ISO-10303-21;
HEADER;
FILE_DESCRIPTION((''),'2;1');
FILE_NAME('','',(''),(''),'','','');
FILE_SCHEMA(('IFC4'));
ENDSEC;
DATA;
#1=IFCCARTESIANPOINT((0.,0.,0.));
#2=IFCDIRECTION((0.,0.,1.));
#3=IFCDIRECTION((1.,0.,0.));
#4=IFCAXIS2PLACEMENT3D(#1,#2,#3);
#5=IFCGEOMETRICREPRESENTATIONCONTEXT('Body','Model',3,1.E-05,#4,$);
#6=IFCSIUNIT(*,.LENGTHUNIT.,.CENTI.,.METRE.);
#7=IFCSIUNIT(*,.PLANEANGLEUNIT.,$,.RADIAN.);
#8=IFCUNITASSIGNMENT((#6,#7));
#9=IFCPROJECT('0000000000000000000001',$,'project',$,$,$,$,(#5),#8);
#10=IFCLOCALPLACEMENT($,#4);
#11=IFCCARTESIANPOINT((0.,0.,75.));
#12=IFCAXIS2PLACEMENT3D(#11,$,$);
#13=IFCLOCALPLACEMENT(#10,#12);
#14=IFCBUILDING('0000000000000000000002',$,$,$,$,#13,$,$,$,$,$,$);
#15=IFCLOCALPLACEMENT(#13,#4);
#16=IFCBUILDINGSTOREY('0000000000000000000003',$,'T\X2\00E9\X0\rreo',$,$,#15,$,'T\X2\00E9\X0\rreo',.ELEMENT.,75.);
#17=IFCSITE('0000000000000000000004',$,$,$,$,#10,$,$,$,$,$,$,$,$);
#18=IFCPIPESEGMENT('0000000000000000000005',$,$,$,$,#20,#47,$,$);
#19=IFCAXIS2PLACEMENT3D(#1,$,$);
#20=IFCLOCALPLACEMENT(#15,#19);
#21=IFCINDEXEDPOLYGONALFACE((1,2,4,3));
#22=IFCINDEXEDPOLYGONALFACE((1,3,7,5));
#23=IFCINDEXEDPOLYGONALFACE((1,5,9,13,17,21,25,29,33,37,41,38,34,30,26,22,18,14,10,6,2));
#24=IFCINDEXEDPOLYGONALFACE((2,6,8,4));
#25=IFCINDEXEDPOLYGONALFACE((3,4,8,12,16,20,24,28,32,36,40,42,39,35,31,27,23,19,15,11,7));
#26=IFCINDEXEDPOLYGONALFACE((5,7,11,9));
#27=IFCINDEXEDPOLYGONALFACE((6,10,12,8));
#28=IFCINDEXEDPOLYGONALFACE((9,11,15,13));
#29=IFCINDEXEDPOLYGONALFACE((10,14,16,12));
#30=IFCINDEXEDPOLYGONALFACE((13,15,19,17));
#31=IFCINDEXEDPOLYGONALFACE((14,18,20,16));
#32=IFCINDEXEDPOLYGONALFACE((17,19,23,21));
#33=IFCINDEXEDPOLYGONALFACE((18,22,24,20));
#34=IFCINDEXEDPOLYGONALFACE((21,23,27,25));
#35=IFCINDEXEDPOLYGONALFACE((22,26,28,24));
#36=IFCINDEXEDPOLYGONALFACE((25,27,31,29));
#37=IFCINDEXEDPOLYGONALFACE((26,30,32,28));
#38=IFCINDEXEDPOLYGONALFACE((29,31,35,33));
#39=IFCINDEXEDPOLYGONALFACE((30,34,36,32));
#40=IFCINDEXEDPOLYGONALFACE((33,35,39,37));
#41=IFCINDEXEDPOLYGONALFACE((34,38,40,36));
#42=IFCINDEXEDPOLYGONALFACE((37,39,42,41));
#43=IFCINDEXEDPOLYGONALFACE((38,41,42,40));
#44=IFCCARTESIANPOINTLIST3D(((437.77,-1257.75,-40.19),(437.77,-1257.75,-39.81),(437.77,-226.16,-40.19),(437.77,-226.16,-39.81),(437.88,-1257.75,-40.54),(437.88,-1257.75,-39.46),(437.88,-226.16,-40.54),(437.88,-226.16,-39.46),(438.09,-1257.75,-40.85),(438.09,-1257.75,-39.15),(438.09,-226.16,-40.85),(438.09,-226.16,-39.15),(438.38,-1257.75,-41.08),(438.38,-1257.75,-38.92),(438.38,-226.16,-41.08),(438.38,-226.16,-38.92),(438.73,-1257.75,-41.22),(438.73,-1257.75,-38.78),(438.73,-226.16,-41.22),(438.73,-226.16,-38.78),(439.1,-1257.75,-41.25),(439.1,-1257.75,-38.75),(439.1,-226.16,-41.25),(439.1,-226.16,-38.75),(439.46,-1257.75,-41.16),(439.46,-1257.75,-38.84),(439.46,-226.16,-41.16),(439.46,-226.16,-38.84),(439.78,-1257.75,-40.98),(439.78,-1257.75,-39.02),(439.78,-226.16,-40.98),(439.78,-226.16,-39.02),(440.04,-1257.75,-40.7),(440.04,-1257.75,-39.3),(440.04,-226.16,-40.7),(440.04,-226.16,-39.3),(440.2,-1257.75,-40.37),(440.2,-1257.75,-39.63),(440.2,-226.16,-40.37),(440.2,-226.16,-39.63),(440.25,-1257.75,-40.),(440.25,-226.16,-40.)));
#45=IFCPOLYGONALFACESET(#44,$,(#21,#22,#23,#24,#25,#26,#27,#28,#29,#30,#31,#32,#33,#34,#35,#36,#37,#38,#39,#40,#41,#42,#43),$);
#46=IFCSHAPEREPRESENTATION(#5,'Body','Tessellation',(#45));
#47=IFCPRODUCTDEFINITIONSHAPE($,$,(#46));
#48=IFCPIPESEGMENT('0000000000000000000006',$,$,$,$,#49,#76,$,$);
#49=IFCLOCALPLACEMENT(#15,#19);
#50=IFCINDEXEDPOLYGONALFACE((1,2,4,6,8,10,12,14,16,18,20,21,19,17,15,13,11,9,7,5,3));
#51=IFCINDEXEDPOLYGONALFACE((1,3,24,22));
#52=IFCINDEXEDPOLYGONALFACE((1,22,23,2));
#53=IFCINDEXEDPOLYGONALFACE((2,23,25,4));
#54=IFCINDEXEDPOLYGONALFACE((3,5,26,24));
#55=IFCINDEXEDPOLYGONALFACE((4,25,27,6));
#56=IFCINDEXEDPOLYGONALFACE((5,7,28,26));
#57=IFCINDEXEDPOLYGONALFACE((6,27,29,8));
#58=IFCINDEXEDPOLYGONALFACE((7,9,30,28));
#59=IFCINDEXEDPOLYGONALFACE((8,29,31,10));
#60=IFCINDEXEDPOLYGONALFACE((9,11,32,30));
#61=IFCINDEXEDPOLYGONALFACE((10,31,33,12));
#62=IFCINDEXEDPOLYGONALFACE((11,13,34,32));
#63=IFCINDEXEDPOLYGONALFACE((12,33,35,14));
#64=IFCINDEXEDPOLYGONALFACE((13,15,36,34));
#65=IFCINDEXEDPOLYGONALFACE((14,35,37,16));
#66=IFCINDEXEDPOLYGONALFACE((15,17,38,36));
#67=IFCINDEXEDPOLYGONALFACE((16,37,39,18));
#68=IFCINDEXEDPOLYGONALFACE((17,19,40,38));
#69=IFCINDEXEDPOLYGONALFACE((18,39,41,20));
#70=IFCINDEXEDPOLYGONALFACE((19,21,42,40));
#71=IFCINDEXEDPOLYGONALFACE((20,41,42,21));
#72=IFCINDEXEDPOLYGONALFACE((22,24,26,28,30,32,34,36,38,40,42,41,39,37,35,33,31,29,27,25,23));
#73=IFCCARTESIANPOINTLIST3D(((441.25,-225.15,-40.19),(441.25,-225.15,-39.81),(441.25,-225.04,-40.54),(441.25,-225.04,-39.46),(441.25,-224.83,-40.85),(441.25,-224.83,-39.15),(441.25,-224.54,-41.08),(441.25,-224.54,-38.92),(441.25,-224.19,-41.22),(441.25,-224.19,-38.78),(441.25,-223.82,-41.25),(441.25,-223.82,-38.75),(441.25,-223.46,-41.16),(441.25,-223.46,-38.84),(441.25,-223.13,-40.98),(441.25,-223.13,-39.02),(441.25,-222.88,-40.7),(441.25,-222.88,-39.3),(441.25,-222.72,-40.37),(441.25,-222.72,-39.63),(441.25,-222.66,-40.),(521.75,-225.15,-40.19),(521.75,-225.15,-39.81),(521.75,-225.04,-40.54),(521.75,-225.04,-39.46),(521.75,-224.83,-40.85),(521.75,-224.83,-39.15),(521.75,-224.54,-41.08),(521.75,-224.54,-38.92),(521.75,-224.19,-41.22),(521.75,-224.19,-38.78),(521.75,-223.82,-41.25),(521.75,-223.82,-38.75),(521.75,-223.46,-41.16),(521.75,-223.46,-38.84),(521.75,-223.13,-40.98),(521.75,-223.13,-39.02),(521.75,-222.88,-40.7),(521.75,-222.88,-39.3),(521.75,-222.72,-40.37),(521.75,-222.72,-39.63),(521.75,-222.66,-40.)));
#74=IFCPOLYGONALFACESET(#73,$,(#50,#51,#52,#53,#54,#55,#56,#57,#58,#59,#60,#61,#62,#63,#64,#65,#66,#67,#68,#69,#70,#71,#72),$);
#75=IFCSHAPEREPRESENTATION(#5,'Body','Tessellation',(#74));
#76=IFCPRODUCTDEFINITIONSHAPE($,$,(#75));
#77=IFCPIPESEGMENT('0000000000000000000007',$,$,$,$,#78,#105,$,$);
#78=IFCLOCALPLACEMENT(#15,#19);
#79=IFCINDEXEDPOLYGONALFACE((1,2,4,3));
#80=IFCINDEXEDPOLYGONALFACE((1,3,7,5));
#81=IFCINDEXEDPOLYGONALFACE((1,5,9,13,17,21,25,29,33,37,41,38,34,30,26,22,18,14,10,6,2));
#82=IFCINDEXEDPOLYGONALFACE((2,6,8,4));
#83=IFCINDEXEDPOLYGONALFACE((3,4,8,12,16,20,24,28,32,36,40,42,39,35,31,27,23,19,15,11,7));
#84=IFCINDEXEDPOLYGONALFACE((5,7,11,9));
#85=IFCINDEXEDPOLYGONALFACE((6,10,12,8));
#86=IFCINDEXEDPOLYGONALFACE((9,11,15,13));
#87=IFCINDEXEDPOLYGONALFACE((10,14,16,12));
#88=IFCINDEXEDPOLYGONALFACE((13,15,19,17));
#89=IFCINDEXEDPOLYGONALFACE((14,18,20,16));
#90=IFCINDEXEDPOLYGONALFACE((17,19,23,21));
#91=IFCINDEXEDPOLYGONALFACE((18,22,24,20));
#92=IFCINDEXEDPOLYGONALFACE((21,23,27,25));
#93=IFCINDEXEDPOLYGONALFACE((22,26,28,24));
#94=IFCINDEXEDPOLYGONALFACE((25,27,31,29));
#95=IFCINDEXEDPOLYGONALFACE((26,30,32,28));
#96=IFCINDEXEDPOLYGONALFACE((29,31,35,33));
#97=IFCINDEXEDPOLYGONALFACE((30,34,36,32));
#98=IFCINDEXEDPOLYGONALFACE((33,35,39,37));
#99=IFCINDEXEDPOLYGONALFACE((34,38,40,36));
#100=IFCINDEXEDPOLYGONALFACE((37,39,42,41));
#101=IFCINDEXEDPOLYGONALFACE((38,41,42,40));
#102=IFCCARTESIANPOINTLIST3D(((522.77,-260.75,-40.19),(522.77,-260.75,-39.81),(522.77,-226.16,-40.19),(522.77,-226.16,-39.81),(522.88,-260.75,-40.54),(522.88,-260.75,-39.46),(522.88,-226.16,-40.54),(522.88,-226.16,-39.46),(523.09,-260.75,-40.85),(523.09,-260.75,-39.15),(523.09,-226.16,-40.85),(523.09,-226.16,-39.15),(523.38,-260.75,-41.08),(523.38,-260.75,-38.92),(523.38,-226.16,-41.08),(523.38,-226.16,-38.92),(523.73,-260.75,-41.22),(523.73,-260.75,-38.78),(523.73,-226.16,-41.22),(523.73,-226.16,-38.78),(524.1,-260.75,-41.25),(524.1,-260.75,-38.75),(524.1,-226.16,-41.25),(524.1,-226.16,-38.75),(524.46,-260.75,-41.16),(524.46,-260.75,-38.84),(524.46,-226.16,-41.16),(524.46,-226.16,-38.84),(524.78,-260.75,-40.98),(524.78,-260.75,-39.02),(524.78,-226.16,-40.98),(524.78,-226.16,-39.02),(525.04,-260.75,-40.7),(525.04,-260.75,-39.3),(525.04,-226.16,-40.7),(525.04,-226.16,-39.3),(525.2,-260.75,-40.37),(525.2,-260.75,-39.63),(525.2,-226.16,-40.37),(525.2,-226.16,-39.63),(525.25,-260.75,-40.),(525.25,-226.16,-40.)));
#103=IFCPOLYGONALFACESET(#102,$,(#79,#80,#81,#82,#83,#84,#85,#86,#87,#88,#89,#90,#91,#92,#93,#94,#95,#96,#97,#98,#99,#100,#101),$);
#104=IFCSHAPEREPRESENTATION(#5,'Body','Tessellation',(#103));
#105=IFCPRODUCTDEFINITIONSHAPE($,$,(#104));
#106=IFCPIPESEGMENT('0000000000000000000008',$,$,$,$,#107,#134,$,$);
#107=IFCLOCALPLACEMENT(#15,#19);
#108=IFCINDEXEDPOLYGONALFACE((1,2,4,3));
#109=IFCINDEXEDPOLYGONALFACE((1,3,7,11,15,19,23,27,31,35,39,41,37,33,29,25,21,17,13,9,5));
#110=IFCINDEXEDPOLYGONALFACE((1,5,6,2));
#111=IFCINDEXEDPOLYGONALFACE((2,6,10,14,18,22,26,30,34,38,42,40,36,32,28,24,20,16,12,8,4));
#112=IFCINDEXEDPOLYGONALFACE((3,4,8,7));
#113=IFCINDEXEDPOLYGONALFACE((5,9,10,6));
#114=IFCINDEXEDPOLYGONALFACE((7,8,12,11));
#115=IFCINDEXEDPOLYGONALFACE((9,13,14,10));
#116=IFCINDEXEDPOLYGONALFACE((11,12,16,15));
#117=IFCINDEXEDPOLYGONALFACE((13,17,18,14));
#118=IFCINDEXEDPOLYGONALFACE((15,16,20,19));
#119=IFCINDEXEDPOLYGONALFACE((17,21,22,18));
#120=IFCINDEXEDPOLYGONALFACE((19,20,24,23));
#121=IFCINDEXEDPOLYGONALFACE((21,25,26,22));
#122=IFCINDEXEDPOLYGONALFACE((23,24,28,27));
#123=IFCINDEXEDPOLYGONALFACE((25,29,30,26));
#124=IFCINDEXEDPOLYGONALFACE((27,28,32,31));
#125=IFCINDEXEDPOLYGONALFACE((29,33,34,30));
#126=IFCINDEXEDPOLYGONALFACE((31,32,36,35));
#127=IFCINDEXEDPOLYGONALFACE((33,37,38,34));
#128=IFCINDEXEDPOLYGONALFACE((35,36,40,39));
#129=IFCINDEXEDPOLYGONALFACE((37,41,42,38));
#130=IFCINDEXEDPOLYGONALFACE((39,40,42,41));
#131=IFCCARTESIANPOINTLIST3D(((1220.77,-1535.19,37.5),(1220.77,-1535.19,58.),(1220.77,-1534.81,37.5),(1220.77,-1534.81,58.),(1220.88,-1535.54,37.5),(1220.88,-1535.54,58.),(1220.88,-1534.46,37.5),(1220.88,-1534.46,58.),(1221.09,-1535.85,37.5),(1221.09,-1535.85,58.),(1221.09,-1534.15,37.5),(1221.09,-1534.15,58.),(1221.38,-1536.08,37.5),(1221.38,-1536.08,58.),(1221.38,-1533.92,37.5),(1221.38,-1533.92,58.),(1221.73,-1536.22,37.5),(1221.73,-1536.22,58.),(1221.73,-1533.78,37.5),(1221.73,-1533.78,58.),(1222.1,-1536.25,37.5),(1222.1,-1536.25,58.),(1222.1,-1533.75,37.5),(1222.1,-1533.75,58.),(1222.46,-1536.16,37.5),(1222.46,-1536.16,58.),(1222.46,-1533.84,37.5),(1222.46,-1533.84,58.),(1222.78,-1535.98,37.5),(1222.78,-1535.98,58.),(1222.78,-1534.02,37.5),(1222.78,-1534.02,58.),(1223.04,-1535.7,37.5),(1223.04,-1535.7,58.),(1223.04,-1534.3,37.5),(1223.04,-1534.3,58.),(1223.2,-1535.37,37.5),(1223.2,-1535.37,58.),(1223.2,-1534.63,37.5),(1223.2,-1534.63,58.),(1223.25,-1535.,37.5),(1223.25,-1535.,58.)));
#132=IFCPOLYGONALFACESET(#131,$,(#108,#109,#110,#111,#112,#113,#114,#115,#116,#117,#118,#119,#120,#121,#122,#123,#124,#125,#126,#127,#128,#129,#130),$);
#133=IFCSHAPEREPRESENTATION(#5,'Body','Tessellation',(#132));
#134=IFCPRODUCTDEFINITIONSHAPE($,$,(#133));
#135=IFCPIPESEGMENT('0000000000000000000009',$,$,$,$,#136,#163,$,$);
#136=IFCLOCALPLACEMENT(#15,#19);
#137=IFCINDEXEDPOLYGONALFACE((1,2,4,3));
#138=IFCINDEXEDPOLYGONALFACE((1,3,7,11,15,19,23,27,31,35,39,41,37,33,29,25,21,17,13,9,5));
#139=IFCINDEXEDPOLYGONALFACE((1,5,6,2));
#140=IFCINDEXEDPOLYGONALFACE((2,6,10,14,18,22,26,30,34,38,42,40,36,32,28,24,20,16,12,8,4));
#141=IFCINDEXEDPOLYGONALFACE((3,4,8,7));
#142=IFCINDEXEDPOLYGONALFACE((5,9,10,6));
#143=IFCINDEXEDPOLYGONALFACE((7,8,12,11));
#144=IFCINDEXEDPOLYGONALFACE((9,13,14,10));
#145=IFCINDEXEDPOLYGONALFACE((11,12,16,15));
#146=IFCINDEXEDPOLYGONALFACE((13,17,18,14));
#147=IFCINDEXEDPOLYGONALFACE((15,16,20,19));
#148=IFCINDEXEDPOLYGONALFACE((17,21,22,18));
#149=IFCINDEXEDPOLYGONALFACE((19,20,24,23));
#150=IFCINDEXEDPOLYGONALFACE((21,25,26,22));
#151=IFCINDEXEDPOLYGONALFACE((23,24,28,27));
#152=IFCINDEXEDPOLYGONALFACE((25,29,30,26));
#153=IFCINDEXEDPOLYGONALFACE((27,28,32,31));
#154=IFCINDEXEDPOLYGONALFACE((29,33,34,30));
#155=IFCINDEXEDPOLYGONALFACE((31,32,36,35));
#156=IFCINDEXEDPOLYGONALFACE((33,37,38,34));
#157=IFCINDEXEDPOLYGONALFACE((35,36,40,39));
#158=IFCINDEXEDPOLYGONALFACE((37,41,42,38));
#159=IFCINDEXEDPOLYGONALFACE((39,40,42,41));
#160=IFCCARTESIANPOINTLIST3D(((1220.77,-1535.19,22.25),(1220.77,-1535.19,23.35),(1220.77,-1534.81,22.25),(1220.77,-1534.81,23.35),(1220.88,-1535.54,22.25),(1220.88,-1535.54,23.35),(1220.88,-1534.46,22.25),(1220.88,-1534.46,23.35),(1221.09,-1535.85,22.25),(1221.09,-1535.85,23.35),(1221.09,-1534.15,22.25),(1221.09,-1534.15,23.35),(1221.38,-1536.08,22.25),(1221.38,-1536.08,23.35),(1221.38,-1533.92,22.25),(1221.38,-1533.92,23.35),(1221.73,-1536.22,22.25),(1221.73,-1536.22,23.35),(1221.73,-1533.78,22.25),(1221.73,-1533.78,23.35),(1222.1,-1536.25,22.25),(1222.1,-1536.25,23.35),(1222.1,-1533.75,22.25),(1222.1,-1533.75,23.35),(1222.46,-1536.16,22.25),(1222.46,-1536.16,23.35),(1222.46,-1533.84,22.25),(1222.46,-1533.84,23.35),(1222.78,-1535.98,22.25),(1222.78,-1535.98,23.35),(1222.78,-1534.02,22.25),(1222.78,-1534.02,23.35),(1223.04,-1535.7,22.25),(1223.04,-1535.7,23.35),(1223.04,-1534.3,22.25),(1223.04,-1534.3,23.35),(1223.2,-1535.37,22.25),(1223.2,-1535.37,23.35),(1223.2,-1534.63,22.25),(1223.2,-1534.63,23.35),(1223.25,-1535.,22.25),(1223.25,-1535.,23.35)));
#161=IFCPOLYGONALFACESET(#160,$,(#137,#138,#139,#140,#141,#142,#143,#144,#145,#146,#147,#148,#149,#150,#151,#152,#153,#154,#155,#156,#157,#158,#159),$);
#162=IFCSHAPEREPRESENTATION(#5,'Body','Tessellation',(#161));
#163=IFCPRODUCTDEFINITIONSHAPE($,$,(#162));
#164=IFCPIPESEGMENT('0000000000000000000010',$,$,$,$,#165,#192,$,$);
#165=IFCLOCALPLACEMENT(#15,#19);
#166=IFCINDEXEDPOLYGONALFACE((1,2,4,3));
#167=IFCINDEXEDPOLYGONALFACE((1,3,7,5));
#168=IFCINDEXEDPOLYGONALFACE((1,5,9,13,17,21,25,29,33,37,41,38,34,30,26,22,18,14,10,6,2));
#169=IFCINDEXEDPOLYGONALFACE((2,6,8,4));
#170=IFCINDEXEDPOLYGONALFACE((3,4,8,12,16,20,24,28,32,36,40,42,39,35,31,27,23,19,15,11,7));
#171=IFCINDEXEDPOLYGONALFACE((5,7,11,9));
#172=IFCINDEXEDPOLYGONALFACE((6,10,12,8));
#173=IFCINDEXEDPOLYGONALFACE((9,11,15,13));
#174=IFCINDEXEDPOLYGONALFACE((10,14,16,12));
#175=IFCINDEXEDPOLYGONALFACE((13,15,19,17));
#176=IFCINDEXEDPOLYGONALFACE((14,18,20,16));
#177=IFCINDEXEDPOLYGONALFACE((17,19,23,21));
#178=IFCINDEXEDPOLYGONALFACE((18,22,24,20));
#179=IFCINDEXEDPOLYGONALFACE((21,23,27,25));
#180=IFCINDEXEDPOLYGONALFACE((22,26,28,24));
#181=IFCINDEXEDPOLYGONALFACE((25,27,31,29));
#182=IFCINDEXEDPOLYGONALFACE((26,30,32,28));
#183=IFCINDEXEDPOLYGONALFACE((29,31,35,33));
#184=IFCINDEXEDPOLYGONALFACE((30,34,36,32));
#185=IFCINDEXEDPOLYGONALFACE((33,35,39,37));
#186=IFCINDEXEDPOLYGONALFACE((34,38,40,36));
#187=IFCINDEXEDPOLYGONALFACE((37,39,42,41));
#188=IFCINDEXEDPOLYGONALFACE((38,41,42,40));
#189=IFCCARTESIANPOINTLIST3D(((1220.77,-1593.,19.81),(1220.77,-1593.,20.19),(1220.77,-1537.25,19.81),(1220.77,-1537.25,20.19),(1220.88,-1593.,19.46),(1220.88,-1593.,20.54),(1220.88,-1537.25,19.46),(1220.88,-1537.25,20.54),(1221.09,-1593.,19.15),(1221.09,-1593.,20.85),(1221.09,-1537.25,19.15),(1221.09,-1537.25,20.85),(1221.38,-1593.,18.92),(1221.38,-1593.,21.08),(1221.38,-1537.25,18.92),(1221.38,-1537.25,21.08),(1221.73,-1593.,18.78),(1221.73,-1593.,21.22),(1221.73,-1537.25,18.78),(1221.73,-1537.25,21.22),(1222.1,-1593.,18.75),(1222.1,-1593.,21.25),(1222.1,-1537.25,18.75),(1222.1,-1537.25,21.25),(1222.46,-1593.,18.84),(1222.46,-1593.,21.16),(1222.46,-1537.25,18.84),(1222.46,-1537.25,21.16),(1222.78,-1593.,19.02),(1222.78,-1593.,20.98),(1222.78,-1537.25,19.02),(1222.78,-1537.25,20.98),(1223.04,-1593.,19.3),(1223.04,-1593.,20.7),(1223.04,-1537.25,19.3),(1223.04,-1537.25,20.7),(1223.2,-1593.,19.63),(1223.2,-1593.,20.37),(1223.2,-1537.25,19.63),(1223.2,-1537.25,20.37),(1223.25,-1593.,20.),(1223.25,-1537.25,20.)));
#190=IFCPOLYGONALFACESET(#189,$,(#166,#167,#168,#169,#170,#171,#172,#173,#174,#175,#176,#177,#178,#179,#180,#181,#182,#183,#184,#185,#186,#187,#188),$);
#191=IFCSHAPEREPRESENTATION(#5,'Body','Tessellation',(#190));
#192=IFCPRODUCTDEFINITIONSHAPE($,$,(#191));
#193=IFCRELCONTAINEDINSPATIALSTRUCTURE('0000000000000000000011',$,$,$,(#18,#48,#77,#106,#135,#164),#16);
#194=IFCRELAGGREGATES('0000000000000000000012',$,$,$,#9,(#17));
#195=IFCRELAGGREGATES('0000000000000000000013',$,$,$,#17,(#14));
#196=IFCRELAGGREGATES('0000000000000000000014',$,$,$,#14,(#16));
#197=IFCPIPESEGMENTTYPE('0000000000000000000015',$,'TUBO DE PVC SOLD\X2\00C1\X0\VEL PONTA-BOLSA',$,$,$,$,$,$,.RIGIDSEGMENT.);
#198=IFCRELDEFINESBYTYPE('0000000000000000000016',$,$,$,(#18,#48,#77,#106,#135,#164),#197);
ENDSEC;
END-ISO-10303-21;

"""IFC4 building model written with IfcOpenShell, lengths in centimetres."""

from ifc_helpers import new_model, si_unit, frame, origin_with_axes, origin_2d_with_axis, place, context, project, spatial, circle, extrude, type_object, element, save


model = new_model("IFC4")

# Units and contexts
model_context = context("Model", 3, precision=1e-05, world=origin_with_axes(), identifier="Body")
ifc_project = project(units=[si_unit("LENGTHUNIT", "METRE", prefix="CENTI"), si_unit("PLANEANGLEUNIT", "RADIAN")], contexts=[model_context])

# Site, building, storey
site_placement = place(None, origin_with_axes())
site = spatial("IfcSite", under=ifc_project, at=site_placement)
building_placement = place(site_placement, frame((0.0, 0.0, 75.0)))
building = spatial("IfcBuilding", under=site, at=building_placement)
storey_placement = place(building_placement, origin_with_axes())
storey = spatial("IfcBuildingStorey", under=building, at=storey_placement, Name="Térreo", LongName="Térreo", CompositionType="ELEMENT", Elevation=75.0)

# Pipe segments
pipe_segment_type_1 = type_object("IfcPipeSegmentType", Name="TUBO DE PVC SOLDÁVEL PONTA-BOLSA", PredefinedType="RIGIDSEGMENT")
pipe_segment_1_placement = place(storey_placement, frame((439.0, -741.96, -38.75), z_axis=(0.0, 0.0, 1.0), x_axis=(1.0, 0.0, 0.0)))
element("IfcPipeSegment", 1, at=pipe_segment_1_placement, inside=storey, type_object=pipe_segment_type_1, context=model_context, shape_type="SolidModel", body=[
    extrude(circle(Radius=1.25, at=origin_2d_with_axis()), frame((0.0, -515.79, -1.25), z_axis=(0.0, 1.0, 0.0), x_axis=(1.0, 0.0, 0.0)), (0.0, 0.0, 1.0), 1031.59),
])
pipe_segment_2_placement = place(storey_placement, frame((481.5, -223.91, -38.75), z_axis=(0.0, 0.0, 1.0), x_axis=(1.0, 0.0, 0.0)))
element("IfcPipeSegment", 2, at=pipe_segment_2_placement, inside=storey, type_object=pipe_segment_type_1, context=model_context, shape_type="SolidModel", body=[
    extrude(circle(Radius=1.25, at=origin_2d_with_axis()), frame((-40.25, 0.0, -1.25), z_axis=(1.0, 0.0, 0.0), x_axis=(0.0, 1.0, 0.0)), (0.0, 0.0, 1.0), 80.5),
])
pipe_segment_3_placement = place(storey_placement, frame((524.0, -243.46, -38.75), z_axis=(0.0, 0.0, 1.0), x_axis=(1.0, 0.0, 0.0)))
element("IfcPipeSegment", 3, at=pipe_segment_3_placement, inside=storey, type_object=pipe_segment_type_1, context=model_context, shape_type="SolidModel", body=[
    extrude(circle(Radius=1.25, at=origin_2d_with_axis()), frame((0.0, 17.29, -1.25), z_axis=(0.0, -1.0, 0.0), x_axis=(1.0, 0.0, 0.0)), (0.0, 0.0, 1.0), 34.59),
])
pipe_segment_4_placement = place(storey_placement, frame((1222.0, -1535.0, 58.0), z_axis=(0.0, 0.0, 1.0), x_axis=(1.0, 0.0, 0.0)))
element("IfcPipeSegment", 4, at=pipe_segment_4_placement, inside=storey, type_object=pipe_segment_type_1, context=model_context, shape_type="SolidModel", body=[
    extrude(circle(Radius=1.25, at=origin_2d_with_axis()), frame((0.0, 0.0, -20.5), z_axis=(0.0, 0.0, 1.0), x_axis=(1.0, 0.0, 0.0)), (0.0, 0.0, 1.0), 20.5),
])
pipe_segment_5_placement = place(storey_placement, frame((1222.0, -1535.0, 23.35), z_axis=(0.0, 0.0, 1.0), x_axis=(1.0, 0.0, 0.0)))
element("IfcPipeSegment", 5, at=pipe_segment_5_placement, inside=storey, type_object=pipe_segment_type_1, context=model_context, shape_type="SolidModel", body=[
    extrude(circle(Radius=1.25, at=origin_2d_with_axis()), frame((0.0, 0.0, -1.1), z_axis=(0.0, 0.0, 1.0), x_axis=(1.0, 0.0, 0.0)), (0.0, 0.0, 1.0), 1.1),
])
pipe_segment_6_placement = place(storey_placement, frame((1222.0, -1565.12, 21.25), z_axis=(0.0, 0.0, 1.0), x_axis=(1.0, 0.0, 0.0)))
element("IfcPipeSegment", 6, at=pipe_segment_6_placement, inside=storey, type_object=pipe_segment_type_1, context=model_context, shape_type="SolidModel", body=[
    extrude(circle(Radius=1.25, at=origin_2d_with_axis()), frame((0.0, -27.88, -1.25), z_axis=(0.0, 1.0, 0.0), x_axis=(1.0, 0.0, 0.0)), (0.0, 0.0, 1.0), 55.75),
])

save(model, "model.ifc")
